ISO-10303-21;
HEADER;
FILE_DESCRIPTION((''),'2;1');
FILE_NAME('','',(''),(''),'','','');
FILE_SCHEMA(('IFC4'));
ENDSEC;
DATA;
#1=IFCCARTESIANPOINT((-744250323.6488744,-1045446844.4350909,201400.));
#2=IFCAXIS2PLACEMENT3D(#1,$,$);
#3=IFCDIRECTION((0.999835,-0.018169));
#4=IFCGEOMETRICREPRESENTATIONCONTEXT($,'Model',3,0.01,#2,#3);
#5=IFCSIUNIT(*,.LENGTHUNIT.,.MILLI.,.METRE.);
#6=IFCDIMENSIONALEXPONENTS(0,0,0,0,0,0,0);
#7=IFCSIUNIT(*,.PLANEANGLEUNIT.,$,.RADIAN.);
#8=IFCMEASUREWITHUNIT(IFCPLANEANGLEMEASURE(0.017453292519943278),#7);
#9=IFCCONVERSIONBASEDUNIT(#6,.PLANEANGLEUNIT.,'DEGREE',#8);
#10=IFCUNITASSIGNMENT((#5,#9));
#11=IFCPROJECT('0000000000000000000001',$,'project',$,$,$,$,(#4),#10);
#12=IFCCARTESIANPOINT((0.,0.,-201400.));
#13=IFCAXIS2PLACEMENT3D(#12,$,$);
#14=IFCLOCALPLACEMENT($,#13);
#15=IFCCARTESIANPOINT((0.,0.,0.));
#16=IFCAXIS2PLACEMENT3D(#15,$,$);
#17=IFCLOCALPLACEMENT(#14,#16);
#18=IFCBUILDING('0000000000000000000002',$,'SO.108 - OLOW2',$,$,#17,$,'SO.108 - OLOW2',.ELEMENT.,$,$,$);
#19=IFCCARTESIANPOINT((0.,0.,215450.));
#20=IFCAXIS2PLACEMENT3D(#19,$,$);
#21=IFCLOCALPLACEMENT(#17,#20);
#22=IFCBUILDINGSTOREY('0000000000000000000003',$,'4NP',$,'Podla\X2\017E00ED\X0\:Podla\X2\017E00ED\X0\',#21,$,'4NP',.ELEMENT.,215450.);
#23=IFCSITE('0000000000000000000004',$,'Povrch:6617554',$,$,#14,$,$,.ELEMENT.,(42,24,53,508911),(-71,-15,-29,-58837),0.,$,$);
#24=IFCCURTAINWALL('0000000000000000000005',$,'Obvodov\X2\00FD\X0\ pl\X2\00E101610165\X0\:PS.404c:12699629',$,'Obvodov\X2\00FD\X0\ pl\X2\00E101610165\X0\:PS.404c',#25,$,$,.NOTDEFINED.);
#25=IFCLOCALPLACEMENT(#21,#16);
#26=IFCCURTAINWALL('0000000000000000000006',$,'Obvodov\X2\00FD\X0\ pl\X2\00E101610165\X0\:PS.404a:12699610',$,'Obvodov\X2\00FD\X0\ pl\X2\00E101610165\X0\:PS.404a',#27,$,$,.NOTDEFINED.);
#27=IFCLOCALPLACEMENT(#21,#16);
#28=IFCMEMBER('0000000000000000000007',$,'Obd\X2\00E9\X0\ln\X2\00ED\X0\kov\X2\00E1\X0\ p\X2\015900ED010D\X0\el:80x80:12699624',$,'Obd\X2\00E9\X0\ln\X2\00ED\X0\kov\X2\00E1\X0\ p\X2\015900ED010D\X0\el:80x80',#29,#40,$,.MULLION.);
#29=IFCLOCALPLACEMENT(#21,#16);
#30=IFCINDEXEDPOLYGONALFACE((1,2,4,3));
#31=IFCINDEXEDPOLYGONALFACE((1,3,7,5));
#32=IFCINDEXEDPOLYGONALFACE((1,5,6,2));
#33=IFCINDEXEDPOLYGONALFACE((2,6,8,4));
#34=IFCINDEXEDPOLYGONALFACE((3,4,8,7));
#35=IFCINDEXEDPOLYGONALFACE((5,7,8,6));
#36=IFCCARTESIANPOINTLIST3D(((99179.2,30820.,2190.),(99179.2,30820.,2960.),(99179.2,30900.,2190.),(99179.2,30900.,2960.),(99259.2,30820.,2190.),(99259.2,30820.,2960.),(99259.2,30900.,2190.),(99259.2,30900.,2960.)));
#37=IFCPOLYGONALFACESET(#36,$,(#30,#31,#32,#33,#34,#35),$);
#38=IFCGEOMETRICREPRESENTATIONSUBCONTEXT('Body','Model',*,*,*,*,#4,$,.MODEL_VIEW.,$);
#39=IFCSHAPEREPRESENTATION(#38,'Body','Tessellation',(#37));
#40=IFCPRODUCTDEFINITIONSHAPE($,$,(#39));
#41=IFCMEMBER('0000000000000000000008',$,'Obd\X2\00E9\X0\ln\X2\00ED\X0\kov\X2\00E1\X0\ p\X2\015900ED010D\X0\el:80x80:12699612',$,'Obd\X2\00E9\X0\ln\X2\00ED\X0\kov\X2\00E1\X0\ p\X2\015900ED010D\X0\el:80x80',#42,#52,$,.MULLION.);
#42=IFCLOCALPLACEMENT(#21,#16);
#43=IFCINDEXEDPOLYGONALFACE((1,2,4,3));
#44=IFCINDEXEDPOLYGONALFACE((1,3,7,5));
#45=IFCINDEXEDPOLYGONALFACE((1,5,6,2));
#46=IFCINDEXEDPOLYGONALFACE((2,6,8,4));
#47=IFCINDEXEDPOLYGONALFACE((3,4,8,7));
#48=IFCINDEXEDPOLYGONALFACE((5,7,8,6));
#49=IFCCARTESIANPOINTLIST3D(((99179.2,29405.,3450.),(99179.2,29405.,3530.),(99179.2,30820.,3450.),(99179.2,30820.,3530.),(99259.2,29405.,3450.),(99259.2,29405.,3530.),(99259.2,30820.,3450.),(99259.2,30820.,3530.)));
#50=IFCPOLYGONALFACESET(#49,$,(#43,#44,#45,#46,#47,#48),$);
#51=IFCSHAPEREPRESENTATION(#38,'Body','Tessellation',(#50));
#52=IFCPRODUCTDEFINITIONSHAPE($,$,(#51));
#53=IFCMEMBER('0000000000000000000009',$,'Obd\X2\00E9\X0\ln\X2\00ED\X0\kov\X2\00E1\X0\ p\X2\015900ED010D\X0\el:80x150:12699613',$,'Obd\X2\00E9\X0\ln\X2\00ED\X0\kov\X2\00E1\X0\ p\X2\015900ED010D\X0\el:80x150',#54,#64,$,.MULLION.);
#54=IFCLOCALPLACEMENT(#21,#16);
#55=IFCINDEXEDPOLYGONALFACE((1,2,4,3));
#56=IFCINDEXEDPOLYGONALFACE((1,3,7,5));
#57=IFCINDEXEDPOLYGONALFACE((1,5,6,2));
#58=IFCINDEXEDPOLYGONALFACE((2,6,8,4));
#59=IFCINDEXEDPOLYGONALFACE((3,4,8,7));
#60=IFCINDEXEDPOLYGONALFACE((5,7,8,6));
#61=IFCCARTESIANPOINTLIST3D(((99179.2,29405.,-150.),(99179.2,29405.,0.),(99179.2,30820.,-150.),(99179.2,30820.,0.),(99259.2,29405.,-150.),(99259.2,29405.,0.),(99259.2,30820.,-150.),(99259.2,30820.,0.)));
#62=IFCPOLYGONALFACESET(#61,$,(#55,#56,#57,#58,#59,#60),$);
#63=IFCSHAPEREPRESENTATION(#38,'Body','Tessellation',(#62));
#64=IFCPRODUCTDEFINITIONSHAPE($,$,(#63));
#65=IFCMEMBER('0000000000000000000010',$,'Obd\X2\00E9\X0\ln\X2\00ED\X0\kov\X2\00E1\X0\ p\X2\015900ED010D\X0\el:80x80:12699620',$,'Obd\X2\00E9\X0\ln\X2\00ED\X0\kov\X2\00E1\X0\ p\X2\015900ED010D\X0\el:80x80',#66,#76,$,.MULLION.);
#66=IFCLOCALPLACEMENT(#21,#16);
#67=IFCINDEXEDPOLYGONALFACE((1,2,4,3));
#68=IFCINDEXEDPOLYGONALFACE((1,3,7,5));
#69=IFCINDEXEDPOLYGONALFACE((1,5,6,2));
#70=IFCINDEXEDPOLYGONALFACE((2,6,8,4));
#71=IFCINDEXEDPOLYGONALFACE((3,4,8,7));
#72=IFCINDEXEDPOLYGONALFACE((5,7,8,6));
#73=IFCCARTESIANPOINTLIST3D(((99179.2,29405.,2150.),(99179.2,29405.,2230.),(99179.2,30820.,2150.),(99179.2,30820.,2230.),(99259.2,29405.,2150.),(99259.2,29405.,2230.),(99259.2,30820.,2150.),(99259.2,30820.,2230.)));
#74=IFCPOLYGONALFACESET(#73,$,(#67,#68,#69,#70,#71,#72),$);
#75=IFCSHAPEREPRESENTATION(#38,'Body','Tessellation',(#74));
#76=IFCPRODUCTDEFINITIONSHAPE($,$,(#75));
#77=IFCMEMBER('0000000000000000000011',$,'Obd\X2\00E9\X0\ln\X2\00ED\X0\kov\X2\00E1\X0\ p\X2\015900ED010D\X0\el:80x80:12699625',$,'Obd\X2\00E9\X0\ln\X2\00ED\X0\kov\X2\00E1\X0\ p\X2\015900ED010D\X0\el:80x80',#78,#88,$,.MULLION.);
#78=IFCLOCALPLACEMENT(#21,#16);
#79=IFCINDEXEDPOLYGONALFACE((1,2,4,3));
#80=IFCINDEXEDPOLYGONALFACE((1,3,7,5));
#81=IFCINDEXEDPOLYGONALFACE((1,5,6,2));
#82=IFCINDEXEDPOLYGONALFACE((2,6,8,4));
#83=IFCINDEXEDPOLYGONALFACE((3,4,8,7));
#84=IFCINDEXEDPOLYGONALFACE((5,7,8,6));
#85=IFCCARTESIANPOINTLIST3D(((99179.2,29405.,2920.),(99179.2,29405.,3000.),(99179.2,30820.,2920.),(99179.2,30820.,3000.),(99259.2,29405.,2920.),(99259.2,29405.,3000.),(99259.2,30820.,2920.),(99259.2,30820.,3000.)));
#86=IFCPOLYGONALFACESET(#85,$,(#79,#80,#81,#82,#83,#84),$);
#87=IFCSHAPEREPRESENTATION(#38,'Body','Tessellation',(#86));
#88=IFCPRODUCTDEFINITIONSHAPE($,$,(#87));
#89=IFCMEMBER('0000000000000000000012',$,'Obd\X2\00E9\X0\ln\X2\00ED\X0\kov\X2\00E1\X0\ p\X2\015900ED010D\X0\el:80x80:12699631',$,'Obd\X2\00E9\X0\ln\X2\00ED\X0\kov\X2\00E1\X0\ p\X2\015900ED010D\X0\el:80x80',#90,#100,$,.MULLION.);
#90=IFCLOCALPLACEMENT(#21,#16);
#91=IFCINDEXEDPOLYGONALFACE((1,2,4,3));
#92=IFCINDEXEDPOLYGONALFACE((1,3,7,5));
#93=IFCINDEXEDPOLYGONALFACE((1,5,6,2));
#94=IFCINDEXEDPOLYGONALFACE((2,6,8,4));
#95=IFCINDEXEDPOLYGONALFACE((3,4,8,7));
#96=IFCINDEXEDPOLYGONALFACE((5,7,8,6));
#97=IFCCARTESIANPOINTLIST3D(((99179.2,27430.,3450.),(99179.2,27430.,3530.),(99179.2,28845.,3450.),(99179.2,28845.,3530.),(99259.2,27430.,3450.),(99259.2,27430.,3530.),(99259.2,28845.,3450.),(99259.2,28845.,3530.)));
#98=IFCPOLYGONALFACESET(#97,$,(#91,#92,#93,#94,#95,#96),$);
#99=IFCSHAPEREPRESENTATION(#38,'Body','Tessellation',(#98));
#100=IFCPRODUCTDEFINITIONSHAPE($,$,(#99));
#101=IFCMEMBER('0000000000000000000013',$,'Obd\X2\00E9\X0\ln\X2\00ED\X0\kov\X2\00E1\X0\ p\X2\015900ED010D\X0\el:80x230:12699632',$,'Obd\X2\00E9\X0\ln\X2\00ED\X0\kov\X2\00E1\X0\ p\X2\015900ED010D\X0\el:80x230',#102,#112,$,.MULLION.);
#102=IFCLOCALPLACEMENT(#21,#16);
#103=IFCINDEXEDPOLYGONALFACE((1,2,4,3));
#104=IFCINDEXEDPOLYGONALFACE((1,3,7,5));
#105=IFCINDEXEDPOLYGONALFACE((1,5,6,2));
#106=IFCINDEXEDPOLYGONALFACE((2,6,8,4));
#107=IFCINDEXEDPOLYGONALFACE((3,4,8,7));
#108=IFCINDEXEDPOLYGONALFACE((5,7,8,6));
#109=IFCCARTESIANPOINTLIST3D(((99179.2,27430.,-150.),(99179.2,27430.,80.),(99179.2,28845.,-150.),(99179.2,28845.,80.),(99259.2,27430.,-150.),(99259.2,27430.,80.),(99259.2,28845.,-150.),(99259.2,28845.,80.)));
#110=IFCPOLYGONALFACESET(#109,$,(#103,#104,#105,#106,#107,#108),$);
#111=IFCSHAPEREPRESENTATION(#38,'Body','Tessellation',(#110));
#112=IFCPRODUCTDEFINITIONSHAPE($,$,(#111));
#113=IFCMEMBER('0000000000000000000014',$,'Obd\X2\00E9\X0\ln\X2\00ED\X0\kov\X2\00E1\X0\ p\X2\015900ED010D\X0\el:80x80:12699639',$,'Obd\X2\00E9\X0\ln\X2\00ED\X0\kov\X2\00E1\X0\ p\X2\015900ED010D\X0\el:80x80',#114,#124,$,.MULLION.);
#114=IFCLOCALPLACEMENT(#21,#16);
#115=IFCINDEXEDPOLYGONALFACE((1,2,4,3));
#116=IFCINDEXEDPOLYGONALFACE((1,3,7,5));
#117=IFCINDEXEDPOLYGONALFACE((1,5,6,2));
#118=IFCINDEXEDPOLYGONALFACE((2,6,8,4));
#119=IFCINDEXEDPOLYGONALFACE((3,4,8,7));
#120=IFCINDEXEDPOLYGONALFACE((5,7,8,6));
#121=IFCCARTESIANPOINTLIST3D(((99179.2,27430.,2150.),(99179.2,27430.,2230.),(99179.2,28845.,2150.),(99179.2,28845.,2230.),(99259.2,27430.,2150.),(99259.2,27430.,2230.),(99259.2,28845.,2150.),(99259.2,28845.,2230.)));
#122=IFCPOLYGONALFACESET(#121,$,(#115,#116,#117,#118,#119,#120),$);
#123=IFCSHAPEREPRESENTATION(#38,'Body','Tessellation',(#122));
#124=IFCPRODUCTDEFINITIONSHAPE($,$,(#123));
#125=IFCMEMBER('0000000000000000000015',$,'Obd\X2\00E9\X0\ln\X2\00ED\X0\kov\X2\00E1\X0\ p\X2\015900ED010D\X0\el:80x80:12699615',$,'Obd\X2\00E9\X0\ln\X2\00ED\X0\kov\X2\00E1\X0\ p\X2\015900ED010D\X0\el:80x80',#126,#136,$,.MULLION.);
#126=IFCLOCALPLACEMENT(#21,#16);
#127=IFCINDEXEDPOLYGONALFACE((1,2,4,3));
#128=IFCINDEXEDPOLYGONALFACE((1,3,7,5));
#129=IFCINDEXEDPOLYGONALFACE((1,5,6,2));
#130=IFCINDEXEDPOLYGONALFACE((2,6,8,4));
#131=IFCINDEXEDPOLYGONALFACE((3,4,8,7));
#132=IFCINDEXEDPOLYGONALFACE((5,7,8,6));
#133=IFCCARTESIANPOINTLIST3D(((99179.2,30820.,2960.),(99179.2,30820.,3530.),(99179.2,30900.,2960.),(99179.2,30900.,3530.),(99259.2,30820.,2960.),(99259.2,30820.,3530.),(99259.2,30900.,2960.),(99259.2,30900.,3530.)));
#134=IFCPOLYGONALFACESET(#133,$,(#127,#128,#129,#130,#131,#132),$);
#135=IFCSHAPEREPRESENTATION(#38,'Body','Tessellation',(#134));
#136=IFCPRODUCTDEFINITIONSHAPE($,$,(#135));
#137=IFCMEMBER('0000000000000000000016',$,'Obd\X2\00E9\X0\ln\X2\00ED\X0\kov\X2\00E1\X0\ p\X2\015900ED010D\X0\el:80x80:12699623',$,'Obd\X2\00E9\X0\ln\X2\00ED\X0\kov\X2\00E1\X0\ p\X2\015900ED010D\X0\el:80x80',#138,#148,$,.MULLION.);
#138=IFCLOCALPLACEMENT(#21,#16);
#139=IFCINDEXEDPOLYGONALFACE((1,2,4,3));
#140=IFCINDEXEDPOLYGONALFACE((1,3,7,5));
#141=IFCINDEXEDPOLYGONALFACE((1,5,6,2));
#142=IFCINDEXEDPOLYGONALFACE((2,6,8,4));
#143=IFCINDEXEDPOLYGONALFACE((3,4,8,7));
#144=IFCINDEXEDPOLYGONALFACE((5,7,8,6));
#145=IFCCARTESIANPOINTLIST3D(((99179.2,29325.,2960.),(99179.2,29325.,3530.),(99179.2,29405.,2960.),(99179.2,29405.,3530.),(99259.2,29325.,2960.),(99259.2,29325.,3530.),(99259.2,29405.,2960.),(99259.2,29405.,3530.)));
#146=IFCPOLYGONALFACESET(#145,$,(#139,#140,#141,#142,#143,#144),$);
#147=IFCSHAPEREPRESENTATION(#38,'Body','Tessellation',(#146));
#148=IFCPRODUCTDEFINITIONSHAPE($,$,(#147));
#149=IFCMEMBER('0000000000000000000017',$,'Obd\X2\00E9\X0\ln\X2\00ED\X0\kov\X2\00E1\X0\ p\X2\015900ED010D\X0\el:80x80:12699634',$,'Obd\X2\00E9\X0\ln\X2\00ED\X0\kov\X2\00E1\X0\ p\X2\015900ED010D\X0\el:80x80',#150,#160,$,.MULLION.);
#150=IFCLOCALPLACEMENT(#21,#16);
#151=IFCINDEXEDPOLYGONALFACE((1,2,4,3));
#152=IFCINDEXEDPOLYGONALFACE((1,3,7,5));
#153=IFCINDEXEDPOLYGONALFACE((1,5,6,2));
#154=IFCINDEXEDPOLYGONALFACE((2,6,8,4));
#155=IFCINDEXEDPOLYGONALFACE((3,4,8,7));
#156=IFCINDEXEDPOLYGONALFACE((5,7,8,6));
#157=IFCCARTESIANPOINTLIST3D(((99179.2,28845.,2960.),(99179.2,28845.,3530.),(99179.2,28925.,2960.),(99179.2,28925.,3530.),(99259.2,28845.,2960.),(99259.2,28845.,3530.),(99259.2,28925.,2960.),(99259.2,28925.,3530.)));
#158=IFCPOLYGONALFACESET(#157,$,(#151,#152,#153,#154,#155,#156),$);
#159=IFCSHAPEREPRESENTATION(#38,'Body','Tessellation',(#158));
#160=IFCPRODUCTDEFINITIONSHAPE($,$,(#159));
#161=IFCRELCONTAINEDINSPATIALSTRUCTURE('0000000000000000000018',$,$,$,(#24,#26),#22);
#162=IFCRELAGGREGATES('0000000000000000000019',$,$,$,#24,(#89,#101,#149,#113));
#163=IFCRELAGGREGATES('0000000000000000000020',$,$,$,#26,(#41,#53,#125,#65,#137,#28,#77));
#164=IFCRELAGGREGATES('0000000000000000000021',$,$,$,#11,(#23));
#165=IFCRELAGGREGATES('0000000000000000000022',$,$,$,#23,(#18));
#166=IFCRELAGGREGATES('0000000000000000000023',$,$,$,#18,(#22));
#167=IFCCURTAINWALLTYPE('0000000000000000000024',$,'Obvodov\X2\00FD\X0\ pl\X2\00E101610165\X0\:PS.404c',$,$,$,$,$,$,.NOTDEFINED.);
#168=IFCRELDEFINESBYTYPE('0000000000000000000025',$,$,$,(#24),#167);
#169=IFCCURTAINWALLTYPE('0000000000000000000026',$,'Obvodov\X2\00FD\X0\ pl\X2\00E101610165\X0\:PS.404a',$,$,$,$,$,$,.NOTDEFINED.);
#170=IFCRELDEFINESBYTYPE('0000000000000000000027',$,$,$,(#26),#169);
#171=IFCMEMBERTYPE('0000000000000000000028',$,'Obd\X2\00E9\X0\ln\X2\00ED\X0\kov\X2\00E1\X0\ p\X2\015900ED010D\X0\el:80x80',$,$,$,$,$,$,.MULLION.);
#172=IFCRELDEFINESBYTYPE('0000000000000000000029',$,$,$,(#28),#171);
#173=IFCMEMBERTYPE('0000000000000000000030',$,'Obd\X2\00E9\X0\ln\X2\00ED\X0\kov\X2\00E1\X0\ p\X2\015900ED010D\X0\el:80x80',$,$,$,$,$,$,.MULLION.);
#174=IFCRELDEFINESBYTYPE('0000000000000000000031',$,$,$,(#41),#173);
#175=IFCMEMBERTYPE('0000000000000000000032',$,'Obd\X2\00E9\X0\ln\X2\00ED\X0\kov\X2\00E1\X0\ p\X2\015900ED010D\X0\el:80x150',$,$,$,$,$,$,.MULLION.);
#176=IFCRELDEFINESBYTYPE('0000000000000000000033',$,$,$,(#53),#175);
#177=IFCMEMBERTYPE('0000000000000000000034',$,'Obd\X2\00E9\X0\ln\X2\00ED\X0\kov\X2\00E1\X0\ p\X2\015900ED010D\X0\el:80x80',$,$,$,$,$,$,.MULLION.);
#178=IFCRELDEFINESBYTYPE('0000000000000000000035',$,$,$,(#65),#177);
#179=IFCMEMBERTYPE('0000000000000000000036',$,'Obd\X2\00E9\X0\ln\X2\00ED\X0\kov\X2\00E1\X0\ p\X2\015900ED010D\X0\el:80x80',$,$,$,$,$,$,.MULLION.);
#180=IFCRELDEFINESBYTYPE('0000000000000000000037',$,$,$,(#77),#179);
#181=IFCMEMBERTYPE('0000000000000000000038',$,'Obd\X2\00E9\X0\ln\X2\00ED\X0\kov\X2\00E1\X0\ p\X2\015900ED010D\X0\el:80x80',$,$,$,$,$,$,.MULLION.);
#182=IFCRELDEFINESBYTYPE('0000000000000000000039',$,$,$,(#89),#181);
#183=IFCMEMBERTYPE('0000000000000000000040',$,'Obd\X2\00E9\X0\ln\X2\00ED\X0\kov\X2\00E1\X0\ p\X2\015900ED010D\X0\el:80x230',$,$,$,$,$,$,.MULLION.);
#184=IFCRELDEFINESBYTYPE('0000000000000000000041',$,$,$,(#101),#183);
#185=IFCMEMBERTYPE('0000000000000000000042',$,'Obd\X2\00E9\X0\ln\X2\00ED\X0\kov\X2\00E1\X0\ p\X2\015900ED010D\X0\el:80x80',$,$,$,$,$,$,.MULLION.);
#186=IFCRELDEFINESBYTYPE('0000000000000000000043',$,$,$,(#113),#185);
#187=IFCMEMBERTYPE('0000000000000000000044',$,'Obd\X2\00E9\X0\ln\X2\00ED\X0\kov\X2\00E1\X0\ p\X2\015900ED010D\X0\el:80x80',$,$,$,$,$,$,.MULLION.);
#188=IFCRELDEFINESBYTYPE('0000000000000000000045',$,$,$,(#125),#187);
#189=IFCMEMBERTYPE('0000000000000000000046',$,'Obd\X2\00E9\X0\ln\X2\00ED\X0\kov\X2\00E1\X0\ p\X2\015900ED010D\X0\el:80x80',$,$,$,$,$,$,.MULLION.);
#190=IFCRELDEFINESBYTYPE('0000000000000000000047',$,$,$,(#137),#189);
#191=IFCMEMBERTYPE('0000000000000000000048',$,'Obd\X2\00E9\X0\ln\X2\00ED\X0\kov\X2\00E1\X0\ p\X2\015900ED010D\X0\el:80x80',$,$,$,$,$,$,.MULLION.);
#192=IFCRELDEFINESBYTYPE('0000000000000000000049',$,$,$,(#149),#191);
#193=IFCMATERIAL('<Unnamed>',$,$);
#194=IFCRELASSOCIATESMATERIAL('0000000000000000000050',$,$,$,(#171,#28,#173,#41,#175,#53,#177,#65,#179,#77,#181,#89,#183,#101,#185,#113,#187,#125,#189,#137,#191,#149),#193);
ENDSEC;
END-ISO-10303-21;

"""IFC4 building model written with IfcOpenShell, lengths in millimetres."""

from ifc_helpers import new_model, entity, si_unit, converted_unit, direction, frame, origin, place, context, subcontext, project, spatial, indexed_curve, outline, extrude, source, transform, mapped, material, type_object, type_shapes, element, aggregate, save


model = new_model("IFC4")

# Units and contexts
model_context = context("Model", 3, precision=0.01, world=frame((-744250323.6488744, -1045446844.4350909, 201400.0)), true_north=direction((0.999835, -0.018169)))
body_context = subcontext(model_context, "Body", "Model", "MODEL_VIEW")
ifc_project = project(units=[si_unit("LENGTHUNIT", "METRE", prefix="MILLI"), converted_unit("PLANEANGLEUNIT", "DEGREE", entity("IfcPlaneAngleMeasure", 0.017453292519943278), si_unit("PLANEANGLEUNIT", "RADIAN"), dimensions=[0, 0, 0, 0, 0, 0, 0])], contexts=[model_context])

# Site, building, storey
site_placement = place(None, frame((0.0, 0.0, -201400.0)))
site = spatial("IfcSite", under=ifc_project, at=site_placement, Name="Povrch:6617554", CompositionType="ELEMENT", RefLatitude=(42, 24, 53, 508911), RefLongitude=(-71, -15, -29, -58837), RefElevation=0.0)
building_placement = place(site_placement, origin())
building = spatial("IfcBuilding", under=site, at=building_placement, Name="SO.108 - OLOW2", LongName="SO.108 - OLOW2", CompositionType="ELEMENT")
storey_placement = place(building_placement, frame((0.0, 0.0, 215450.0)))
storey = spatial("IfcBuildingStorey", under=building, at=storey_placement, Name="4NP", ObjectType="Podlaží:Podlaží", LongName="4NP", CompositionType="ELEMENT", Elevation=215450.0)

# Curtain walls, members
ifc_material_1 = material(Name="<Unnamed>")
curtain_wall_type_1 = type_object("IfcCurtainWallType", Name="Obvodový plášť:PS.404c", PredefinedType="NOTDEFINED")
curtain_wall_1_placement = place(storey_placement, frame((0.0, 0.0, -215450.0)))
curtain_wall_1 = element("IfcCurtainWall", 1, at=curtain_wall_1_placement, inside=storey, type_object=curtain_wall_type_1, Name="Obvodový plášť:PS.404c:12699629", ObjectType="Obvodový plášť:PS.404c", PredefinedType="NOTDEFINED")
curtain_wall_type_2 = type_object("IfcCurtainWallType", Name="Obvodový plášť:PS.404a", PredefinedType="NOTDEFINED")
curtain_wall_2_placement = place(storey_placement, frame((0.0, 0.0, -215450.0)))
curtain_wall_2 = element("IfcCurtainWall", 2, at=curtain_wall_2_placement, inside=storey, type_object=curtain_wall_type_2, Name="Obvodový plášť:PS.404a:12699610", ObjectType="Obvodový plášť:PS.404a", PredefinedType="NOTDEFINED")
member_type_1 = type_object("IfcMemberType", Name="Obdélníková příčel:80x80", PredefinedType="MULLION", material=ifc_material_1)
shared_shape_1 = source(origin(), body_context, "Body", "SweptSolid", [
    extrude(outline(indexed_curve([(-40.0, -40.0), (40.0, -40.0), (40.0, 40.0), (-40.0, 40.0), (-40.0, -40.0)], self_intersect=False)), frame((-40.0, 0.0, -770.0), z_axis=(0.0, 0.0, 1.0), x_axis=(-1.0, 0.0, 0.0)), (0.0, 0.0, 1.0), 770.0),
])
type_shapes(member_type_1, [shared_shape_1])
member_1_placement = place(curtain_wall_2_placement, frame((99219.2, 30900.0, 218410.0), z_axis=(0.0, 0.0, 1.0), x_axis=(0.0, 1.0, 0.0)))
member_1 = element("IfcMember", 3, at=member_1_placement, type_object=member_type_1, material=ifc_material_1, Name="Obdélníková příčel:80x80:12699624", ObjectType="Obdélníková příčel:80x80", PredefinedType="MULLION", context=body_context, shape_type="MappedRepresentation", body=[
    mapped(shared_shape_1, transform((0.0, 0.0, 0.0), scale=1.0)),
])
member_type_2 = type_object("IfcMemberType", Name="Obdélníková příčel:80x80", PredefinedType="MULLION", material=ifc_material_1)
shared_shape_2 = source(origin(), body_context, "Body", "SweptSolid", [
    extrude(outline(indexed_curve([(-40.0, -40.0), (40.0, -40.0), (40.0, 40.0), (-40.0, 40.0), (-40.0, -40.0)], self_intersect=False)), frame((-40.0, 0.0, -1415.0), z_axis=(0.0, 0.0, 1.0), x_axis=(-1.0, 0.0, 0.0)), (0.0, 0.0, 1.0), 1415.0),
])
type_shapes(member_type_2, [shared_shape_2])
member_2_placement = place(curtain_wall_2_placement, frame((99219.2, 29405.0, 218980.0), z_axis=(0.0, -1.0, 0.0), x_axis=(0.0, 0.0, 1.0)))
member_2 = element("IfcMember", 4, at=member_2_placement, type_object=member_type_2, material=ifc_material_1, Name="Obdélníková příčel:80x80:12699612", ObjectType="Obdélníková příčel:80x80", PredefinedType="MULLION", context=body_context, shape_type="MappedRepresentation", body=[
    mapped(shared_shape_2, transform((0.0, 0.0, 0.0), scale=1.0)),
])
member_type_3 = type_object("IfcMemberType", Name="Obdélníková příčel:80x150", PredefinedType="MULLION", material=ifc_material_1)
shared_shape_3 = source(origin(), body_context, "Body", "SweptSolid", [
    extrude(outline(indexed_curve([(-75.0, -40.0), (75.0, -40.0), (75.0, 40.0), (-75.0, 40.0), (-75.0, -40.0)], self_intersect=False)), frame((-75.0, 0.0, -1415.0), z_axis=(0.0, 0.0, 1.0), x_axis=(-1.0, 0.0, 0.0)), (0.0, 0.0, 1.0), 1415.0),
])
type_shapes(member_type_3, [shared_shape_3])
member_3_placement = place(curtain_wall_2_placement, frame((99219.2, 30820.0, 215300.0), z_axis=(0.0, 1.0, 0.0), x_axis=(0.0, 0.0, -1.0)))
member_3 = element("IfcMember", 5, at=member_3_placement, type_object=member_type_3, material=ifc_material_1, Name="Obdélníková příčel:80x150:12699613", ObjectType="Obdélníková příčel:80x150", PredefinedType="MULLION", context=body_context, shape_type="MappedRepresentation", body=[
    mapped(shared_shape_3, transform((0.0, 0.0, 0.0), scale=1.0)),
])
member_type_4 = type_object("IfcMemberType", Name="Obdélníková příčel:80x80", PredefinedType="MULLION", material=ifc_material_1)
shared_shape_4 = source(origin(), body_context, "Body", "SweptSolid", [
    extrude(outline(indexed_curve([(-40.0, -40.0), (40.0, -40.0), (40.0, 40.0), (-40.0, 40.0), (-40.0, -40.0)], self_intersect=False)), frame((0.0, 0.0, -1415.0), z_axis=(0.0, 0.0, 1.0), x_axis=(-1.0, 0.0, 0.0)), (0.0, 0.0, 1.0), 1415.0),
])
type_shapes(member_type_4, [shared_shape_4])
member_4_placement = place(curtain_wall_2_placement, frame((99219.2, 29405.0, 217640.0), z_axis=(0.0, -1.0, 0.0), x_axis=(0.0, 0.0, 1.0)))
member_4 = element("IfcMember", 6, at=member_4_placement, type_object=member_type_4, material=ifc_material_1, Name="Obdélníková příčel:80x80:12699620", ObjectType="Obdélníková příčel:80x80", PredefinedType="MULLION", context=body_context, shape_type="MappedRepresentation", body=[
    mapped(shared_shape_4, transform((0.0, 0.0, 0.0), scale=1.0)),
])
member_type_5 = type_object("IfcMemberType", Name="Obdélníková příčel:80x80", PredefinedType="MULLION", material=ifc_material_1)
shared_shape_5 = source(origin(), body_context, "Body", "SweptSolid", [
    extrude(outline(indexed_curve([(-40.0, -40.0), (40.0, -40.0), (40.0, 40.0), (-40.0, 40.0), (-40.0, -40.0)], self_intersect=False)), frame((0.0, 0.0, -1415.0), z_axis=(0.0, 0.0, 1.0), x_axis=(-1.0, 0.0, 0.0)), (0.0, 0.0, 1.0), 1415.0),
])
type_shapes(member_type_5, [shared_shape_5])
member_5_placement = place(curtain_wall_2_placement, frame((99219.2, 29405.0, 218410.0), z_axis=(0.0, -1.0, 0.0), x_axis=(0.0, 0.0, 1.0)))
member_5 = element("IfcMember", 7, at=member_5_placement, type_object=member_type_5, material=ifc_material_1, Name="Obdélníková příčel:80x80:12699625", ObjectType="Obdélníková příčel:80x80", PredefinedType="MULLION", context=body_context, shape_type="MappedRepresentation", body=[
    mapped(shared_shape_5, transform((0.0, 0.0, 0.0), scale=1.0)),
])

# Members
member_type_6 = type_object("IfcMemberType", Name="Obdélníková příčel:80x80", PredefinedType="MULLION", material=ifc_material_1)
shared_shape_6 = source(origin(), body_context, "Body", "SweptSolid", [
    extrude(outline(indexed_curve([(-40.0, -40.0), (40.0, -40.0), (40.0, 40.0), (-40.0, 40.0), (-40.0, -40.0)], self_intersect=False)), frame((-40.0, 0.0, -1415.0), z_axis=(0.0, 0.0, 1.0), x_axis=(-1.0, 0.0, 0.0)), (0.0, 0.0, 1.0), 1415.0),
])
type_shapes(member_type_6, [shared_shape_6])
member_6_placement = place(curtain_wall_1_placement, frame((99219.2, 27430.0, 218980.0), z_axis=(0.0, -1.0, 0.0), x_axis=(0.0, 0.0, 1.0)))
member_6 = element("IfcMember", 8, at=member_6_placement, type_object=member_type_6, material=ifc_material_1, Name="Obdélníková příčel:80x80:12699631", ObjectType="Obdélníková příčel:80x80", PredefinedType="MULLION", context=body_context, shape_type="MappedRepresentation", body=[
    mapped(shared_shape_6, transform((0.0, 0.0, 0.0), scale=1.0)),
])
member_type_7 = type_object("IfcMemberType", Name="Obdélníková příčel:80x230", PredefinedType="MULLION", material=ifc_material_1)
shared_shape_7 = source(origin(), body_context, "Body", "SweptSolid", [
    extrude(outline(indexed_curve([(-115.0, -40.0), (115.0, -40.0), (115.0, 40.0), (-115.0, 40.0), (-115.0, -40.0)], self_intersect=False)), frame((-115.0, 0.0, -1415.0), z_axis=(0.0, 0.0, 1.0), x_axis=(-1.0, 0.0, 0.0)), (0.0, 0.0, 1.0), 1415.0),
])
type_shapes(member_type_7, [shared_shape_7])
member_7_placement = place(curtain_wall_1_placement, frame((99219.2, 28845.0, 215300.0), z_axis=(0.0, 1.0, 0.0), x_axis=(0.0, 0.0, -1.0)))
member_7 = element("IfcMember", 9, at=member_7_placement, type_object=member_type_7, material=ifc_material_1, Name="Obdélníková příčel:80x230:12699632", ObjectType="Obdélníková příčel:80x230", PredefinedType="MULLION", context=body_context, shape_type="MappedRepresentation", body=[
    mapped(shared_shape_7, transform((0.0, 0.0, 0.0), scale=1.0)),
])
member_type_8 = type_object("IfcMemberType", Name="Obdélníková příčel:80x80", PredefinedType="MULLION", material=ifc_material_1)
shared_shape_8 = source(origin(), body_context, "Body", "SweptSolid", [
    extrude(outline(indexed_curve([(-40.0, -40.0), (40.0, -40.0), (40.0, 40.0), (-40.0, 40.0), (-40.0, -40.0)], self_intersect=False)), frame((0.0, 0.0, -1415.0), z_axis=(0.0, 0.0, 1.0), x_axis=(-1.0, 0.0, 0.0)), (0.0, 0.0, 1.0), 1415.0),
])
type_shapes(member_type_8, [shared_shape_8])
member_8_placement = place(curtain_wall_1_placement, frame((99219.2, 27430.0, 217640.0), z_axis=(0.0, -1.0, 0.0), x_axis=(0.0, 0.0, 1.0)))
member_8 = element("IfcMember", 10, at=member_8_placement, type_object=member_type_8, material=ifc_material_1, Name="Obdélníková příčel:80x80:12699639", ObjectType="Obdélníková příčel:80x80", PredefinedType="MULLION", context=body_context, shape_type="MappedRepresentation", body=[
    mapped(shared_shape_8, transform((0.0, 0.0, 0.0), scale=1.0)),
])
member_type_9 = type_object("IfcMemberType", Name="Obdélníková příčel:80x80", PredefinedType="MULLION", material=ifc_material_1)
shared_shape_9 = source(origin(), body_context, "Body", "SweptSolid", [
    extrude(outline(indexed_curve([(-40.0, -40.0), (40.0, -40.0), (40.0, 40.0), (-40.0, 40.0), (-40.0, -40.0)], self_intersect=False)), frame((-40.0, 0.0, -570.0), z_axis=(0.0, 0.0, 1.0), x_axis=(-1.0, 0.0, 0.0)), (0.0, 0.0, 1.0), 570.0),
])
type_shapes(member_type_9, [shared_shape_9])
member_9_placement = place(curtain_wall_2_placement, frame((99219.2, 30900.0, 218980.0), z_axis=(0.0, 0.0, 1.0), x_axis=(0.0, 1.0, 0.0)))
member_9 = element("IfcMember", 11, at=member_9_placement, type_object=member_type_9, material=ifc_material_1, Name="Obdélníková příčel:80x80:12699615", ObjectType="Obdélníková příčel:80x80", PredefinedType="MULLION", context=body_context, shape_type="MappedRepresentation", body=[
    mapped(shared_shape_9, transform((0.0, 0.0, 0.0), scale=1.0)),
])
member_type_10 = type_object("IfcMemberType", Name="Obdélníková příčel:80x80", PredefinedType="MULLION", material=ifc_material_1)
shared_shape_10 = source(origin(), body_context, "Body", "SweptSolid", [
    extrude(outline(indexed_curve([(-40.0, -40.0), (40.0, -40.0), (40.0, 40.0), (-40.0, 40.0), (-40.0, -40.0)], self_intersect=False)), frame((-40.0, 0.0, -570.0), z_axis=(0.0, 0.0, 1.0), x_axis=(-1.0, 0.0, 0.0)), (0.0, 0.0, 1.0), 570.0),
])
type_shapes(member_type_10, [shared_shape_10])
member_10_placement = place(curtain_wall_2_placement, frame((99219.2, 29325.0, 218410.0), z_axis=(0.0, 0.0, -1.0), x_axis=(0.0, -1.0, 0.0)))
member_10 = element("IfcMember", 12, at=member_10_placement, type_object=member_type_10, material=ifc_material_1, Name="Obdélníková příčel:80x80:12699623", ObjectType="Obdélníková příčel:80x80", PredefinedType="MULLION", context=body_context, shape_type="MappedRepresentation", body=[
    mapped(shared_shape_10, transform((0.0, 0.0, 0.0), scale=1.0)),
])
member_type_11 = type_object("IfcMemberType", Name="Obdélníková příčel:80x80", PredefinedType="MULLION", material=ifc_material_1)
shared_shape_11 = source(origin(), body_context, "Body", "SweptSolid", [
    extrude(outline(indexed_curve([(-40.0, -40.0), (40.0, -40.0), (40.0, 40.0), (-40.0, 40.0), (-40.0, -40.0)], self_intersect=False)), frame((-40.0, 0.0, -570.0), z_axis=(0.0, 0.0, 1.0), x_axis=(-1.0, 0.0, 0.0)), (0.0, 0.0, 1.0), 570.0),
])
type_shapes(member_type_11, [shared_shape_11])
member_11_placement = place(curtain_wall_1_placement, frame((99219.2, 28925.0, 218980.0), z_axis=(0.0, 0.0, 1.0), x_axis=(0.0, 1.0, 0.0)))
member_11 = element("IfcMember", 13, at=member_11_placement, type_object=member_type_11, material=ifc_material_1, Name="Obdélníková příčel:80x80:12699634", ObjectType="Obdélníková příčel:80x80", PredefinedType="MULLION", context=body_context, shape_type="MappedRepresentation", body=[
    mapped(shared_shape_11, transform((0.0, 0.0, 0.0), scale=1.0)),
])

aggregate(curtain_wall_1, [member_6, member_7, member_11, member_8])

aggregate(curtain_wall_2, [member_2, member_3, member_9, member_4, member_10, member_1, member_5])

save(model, "model.ifc")
